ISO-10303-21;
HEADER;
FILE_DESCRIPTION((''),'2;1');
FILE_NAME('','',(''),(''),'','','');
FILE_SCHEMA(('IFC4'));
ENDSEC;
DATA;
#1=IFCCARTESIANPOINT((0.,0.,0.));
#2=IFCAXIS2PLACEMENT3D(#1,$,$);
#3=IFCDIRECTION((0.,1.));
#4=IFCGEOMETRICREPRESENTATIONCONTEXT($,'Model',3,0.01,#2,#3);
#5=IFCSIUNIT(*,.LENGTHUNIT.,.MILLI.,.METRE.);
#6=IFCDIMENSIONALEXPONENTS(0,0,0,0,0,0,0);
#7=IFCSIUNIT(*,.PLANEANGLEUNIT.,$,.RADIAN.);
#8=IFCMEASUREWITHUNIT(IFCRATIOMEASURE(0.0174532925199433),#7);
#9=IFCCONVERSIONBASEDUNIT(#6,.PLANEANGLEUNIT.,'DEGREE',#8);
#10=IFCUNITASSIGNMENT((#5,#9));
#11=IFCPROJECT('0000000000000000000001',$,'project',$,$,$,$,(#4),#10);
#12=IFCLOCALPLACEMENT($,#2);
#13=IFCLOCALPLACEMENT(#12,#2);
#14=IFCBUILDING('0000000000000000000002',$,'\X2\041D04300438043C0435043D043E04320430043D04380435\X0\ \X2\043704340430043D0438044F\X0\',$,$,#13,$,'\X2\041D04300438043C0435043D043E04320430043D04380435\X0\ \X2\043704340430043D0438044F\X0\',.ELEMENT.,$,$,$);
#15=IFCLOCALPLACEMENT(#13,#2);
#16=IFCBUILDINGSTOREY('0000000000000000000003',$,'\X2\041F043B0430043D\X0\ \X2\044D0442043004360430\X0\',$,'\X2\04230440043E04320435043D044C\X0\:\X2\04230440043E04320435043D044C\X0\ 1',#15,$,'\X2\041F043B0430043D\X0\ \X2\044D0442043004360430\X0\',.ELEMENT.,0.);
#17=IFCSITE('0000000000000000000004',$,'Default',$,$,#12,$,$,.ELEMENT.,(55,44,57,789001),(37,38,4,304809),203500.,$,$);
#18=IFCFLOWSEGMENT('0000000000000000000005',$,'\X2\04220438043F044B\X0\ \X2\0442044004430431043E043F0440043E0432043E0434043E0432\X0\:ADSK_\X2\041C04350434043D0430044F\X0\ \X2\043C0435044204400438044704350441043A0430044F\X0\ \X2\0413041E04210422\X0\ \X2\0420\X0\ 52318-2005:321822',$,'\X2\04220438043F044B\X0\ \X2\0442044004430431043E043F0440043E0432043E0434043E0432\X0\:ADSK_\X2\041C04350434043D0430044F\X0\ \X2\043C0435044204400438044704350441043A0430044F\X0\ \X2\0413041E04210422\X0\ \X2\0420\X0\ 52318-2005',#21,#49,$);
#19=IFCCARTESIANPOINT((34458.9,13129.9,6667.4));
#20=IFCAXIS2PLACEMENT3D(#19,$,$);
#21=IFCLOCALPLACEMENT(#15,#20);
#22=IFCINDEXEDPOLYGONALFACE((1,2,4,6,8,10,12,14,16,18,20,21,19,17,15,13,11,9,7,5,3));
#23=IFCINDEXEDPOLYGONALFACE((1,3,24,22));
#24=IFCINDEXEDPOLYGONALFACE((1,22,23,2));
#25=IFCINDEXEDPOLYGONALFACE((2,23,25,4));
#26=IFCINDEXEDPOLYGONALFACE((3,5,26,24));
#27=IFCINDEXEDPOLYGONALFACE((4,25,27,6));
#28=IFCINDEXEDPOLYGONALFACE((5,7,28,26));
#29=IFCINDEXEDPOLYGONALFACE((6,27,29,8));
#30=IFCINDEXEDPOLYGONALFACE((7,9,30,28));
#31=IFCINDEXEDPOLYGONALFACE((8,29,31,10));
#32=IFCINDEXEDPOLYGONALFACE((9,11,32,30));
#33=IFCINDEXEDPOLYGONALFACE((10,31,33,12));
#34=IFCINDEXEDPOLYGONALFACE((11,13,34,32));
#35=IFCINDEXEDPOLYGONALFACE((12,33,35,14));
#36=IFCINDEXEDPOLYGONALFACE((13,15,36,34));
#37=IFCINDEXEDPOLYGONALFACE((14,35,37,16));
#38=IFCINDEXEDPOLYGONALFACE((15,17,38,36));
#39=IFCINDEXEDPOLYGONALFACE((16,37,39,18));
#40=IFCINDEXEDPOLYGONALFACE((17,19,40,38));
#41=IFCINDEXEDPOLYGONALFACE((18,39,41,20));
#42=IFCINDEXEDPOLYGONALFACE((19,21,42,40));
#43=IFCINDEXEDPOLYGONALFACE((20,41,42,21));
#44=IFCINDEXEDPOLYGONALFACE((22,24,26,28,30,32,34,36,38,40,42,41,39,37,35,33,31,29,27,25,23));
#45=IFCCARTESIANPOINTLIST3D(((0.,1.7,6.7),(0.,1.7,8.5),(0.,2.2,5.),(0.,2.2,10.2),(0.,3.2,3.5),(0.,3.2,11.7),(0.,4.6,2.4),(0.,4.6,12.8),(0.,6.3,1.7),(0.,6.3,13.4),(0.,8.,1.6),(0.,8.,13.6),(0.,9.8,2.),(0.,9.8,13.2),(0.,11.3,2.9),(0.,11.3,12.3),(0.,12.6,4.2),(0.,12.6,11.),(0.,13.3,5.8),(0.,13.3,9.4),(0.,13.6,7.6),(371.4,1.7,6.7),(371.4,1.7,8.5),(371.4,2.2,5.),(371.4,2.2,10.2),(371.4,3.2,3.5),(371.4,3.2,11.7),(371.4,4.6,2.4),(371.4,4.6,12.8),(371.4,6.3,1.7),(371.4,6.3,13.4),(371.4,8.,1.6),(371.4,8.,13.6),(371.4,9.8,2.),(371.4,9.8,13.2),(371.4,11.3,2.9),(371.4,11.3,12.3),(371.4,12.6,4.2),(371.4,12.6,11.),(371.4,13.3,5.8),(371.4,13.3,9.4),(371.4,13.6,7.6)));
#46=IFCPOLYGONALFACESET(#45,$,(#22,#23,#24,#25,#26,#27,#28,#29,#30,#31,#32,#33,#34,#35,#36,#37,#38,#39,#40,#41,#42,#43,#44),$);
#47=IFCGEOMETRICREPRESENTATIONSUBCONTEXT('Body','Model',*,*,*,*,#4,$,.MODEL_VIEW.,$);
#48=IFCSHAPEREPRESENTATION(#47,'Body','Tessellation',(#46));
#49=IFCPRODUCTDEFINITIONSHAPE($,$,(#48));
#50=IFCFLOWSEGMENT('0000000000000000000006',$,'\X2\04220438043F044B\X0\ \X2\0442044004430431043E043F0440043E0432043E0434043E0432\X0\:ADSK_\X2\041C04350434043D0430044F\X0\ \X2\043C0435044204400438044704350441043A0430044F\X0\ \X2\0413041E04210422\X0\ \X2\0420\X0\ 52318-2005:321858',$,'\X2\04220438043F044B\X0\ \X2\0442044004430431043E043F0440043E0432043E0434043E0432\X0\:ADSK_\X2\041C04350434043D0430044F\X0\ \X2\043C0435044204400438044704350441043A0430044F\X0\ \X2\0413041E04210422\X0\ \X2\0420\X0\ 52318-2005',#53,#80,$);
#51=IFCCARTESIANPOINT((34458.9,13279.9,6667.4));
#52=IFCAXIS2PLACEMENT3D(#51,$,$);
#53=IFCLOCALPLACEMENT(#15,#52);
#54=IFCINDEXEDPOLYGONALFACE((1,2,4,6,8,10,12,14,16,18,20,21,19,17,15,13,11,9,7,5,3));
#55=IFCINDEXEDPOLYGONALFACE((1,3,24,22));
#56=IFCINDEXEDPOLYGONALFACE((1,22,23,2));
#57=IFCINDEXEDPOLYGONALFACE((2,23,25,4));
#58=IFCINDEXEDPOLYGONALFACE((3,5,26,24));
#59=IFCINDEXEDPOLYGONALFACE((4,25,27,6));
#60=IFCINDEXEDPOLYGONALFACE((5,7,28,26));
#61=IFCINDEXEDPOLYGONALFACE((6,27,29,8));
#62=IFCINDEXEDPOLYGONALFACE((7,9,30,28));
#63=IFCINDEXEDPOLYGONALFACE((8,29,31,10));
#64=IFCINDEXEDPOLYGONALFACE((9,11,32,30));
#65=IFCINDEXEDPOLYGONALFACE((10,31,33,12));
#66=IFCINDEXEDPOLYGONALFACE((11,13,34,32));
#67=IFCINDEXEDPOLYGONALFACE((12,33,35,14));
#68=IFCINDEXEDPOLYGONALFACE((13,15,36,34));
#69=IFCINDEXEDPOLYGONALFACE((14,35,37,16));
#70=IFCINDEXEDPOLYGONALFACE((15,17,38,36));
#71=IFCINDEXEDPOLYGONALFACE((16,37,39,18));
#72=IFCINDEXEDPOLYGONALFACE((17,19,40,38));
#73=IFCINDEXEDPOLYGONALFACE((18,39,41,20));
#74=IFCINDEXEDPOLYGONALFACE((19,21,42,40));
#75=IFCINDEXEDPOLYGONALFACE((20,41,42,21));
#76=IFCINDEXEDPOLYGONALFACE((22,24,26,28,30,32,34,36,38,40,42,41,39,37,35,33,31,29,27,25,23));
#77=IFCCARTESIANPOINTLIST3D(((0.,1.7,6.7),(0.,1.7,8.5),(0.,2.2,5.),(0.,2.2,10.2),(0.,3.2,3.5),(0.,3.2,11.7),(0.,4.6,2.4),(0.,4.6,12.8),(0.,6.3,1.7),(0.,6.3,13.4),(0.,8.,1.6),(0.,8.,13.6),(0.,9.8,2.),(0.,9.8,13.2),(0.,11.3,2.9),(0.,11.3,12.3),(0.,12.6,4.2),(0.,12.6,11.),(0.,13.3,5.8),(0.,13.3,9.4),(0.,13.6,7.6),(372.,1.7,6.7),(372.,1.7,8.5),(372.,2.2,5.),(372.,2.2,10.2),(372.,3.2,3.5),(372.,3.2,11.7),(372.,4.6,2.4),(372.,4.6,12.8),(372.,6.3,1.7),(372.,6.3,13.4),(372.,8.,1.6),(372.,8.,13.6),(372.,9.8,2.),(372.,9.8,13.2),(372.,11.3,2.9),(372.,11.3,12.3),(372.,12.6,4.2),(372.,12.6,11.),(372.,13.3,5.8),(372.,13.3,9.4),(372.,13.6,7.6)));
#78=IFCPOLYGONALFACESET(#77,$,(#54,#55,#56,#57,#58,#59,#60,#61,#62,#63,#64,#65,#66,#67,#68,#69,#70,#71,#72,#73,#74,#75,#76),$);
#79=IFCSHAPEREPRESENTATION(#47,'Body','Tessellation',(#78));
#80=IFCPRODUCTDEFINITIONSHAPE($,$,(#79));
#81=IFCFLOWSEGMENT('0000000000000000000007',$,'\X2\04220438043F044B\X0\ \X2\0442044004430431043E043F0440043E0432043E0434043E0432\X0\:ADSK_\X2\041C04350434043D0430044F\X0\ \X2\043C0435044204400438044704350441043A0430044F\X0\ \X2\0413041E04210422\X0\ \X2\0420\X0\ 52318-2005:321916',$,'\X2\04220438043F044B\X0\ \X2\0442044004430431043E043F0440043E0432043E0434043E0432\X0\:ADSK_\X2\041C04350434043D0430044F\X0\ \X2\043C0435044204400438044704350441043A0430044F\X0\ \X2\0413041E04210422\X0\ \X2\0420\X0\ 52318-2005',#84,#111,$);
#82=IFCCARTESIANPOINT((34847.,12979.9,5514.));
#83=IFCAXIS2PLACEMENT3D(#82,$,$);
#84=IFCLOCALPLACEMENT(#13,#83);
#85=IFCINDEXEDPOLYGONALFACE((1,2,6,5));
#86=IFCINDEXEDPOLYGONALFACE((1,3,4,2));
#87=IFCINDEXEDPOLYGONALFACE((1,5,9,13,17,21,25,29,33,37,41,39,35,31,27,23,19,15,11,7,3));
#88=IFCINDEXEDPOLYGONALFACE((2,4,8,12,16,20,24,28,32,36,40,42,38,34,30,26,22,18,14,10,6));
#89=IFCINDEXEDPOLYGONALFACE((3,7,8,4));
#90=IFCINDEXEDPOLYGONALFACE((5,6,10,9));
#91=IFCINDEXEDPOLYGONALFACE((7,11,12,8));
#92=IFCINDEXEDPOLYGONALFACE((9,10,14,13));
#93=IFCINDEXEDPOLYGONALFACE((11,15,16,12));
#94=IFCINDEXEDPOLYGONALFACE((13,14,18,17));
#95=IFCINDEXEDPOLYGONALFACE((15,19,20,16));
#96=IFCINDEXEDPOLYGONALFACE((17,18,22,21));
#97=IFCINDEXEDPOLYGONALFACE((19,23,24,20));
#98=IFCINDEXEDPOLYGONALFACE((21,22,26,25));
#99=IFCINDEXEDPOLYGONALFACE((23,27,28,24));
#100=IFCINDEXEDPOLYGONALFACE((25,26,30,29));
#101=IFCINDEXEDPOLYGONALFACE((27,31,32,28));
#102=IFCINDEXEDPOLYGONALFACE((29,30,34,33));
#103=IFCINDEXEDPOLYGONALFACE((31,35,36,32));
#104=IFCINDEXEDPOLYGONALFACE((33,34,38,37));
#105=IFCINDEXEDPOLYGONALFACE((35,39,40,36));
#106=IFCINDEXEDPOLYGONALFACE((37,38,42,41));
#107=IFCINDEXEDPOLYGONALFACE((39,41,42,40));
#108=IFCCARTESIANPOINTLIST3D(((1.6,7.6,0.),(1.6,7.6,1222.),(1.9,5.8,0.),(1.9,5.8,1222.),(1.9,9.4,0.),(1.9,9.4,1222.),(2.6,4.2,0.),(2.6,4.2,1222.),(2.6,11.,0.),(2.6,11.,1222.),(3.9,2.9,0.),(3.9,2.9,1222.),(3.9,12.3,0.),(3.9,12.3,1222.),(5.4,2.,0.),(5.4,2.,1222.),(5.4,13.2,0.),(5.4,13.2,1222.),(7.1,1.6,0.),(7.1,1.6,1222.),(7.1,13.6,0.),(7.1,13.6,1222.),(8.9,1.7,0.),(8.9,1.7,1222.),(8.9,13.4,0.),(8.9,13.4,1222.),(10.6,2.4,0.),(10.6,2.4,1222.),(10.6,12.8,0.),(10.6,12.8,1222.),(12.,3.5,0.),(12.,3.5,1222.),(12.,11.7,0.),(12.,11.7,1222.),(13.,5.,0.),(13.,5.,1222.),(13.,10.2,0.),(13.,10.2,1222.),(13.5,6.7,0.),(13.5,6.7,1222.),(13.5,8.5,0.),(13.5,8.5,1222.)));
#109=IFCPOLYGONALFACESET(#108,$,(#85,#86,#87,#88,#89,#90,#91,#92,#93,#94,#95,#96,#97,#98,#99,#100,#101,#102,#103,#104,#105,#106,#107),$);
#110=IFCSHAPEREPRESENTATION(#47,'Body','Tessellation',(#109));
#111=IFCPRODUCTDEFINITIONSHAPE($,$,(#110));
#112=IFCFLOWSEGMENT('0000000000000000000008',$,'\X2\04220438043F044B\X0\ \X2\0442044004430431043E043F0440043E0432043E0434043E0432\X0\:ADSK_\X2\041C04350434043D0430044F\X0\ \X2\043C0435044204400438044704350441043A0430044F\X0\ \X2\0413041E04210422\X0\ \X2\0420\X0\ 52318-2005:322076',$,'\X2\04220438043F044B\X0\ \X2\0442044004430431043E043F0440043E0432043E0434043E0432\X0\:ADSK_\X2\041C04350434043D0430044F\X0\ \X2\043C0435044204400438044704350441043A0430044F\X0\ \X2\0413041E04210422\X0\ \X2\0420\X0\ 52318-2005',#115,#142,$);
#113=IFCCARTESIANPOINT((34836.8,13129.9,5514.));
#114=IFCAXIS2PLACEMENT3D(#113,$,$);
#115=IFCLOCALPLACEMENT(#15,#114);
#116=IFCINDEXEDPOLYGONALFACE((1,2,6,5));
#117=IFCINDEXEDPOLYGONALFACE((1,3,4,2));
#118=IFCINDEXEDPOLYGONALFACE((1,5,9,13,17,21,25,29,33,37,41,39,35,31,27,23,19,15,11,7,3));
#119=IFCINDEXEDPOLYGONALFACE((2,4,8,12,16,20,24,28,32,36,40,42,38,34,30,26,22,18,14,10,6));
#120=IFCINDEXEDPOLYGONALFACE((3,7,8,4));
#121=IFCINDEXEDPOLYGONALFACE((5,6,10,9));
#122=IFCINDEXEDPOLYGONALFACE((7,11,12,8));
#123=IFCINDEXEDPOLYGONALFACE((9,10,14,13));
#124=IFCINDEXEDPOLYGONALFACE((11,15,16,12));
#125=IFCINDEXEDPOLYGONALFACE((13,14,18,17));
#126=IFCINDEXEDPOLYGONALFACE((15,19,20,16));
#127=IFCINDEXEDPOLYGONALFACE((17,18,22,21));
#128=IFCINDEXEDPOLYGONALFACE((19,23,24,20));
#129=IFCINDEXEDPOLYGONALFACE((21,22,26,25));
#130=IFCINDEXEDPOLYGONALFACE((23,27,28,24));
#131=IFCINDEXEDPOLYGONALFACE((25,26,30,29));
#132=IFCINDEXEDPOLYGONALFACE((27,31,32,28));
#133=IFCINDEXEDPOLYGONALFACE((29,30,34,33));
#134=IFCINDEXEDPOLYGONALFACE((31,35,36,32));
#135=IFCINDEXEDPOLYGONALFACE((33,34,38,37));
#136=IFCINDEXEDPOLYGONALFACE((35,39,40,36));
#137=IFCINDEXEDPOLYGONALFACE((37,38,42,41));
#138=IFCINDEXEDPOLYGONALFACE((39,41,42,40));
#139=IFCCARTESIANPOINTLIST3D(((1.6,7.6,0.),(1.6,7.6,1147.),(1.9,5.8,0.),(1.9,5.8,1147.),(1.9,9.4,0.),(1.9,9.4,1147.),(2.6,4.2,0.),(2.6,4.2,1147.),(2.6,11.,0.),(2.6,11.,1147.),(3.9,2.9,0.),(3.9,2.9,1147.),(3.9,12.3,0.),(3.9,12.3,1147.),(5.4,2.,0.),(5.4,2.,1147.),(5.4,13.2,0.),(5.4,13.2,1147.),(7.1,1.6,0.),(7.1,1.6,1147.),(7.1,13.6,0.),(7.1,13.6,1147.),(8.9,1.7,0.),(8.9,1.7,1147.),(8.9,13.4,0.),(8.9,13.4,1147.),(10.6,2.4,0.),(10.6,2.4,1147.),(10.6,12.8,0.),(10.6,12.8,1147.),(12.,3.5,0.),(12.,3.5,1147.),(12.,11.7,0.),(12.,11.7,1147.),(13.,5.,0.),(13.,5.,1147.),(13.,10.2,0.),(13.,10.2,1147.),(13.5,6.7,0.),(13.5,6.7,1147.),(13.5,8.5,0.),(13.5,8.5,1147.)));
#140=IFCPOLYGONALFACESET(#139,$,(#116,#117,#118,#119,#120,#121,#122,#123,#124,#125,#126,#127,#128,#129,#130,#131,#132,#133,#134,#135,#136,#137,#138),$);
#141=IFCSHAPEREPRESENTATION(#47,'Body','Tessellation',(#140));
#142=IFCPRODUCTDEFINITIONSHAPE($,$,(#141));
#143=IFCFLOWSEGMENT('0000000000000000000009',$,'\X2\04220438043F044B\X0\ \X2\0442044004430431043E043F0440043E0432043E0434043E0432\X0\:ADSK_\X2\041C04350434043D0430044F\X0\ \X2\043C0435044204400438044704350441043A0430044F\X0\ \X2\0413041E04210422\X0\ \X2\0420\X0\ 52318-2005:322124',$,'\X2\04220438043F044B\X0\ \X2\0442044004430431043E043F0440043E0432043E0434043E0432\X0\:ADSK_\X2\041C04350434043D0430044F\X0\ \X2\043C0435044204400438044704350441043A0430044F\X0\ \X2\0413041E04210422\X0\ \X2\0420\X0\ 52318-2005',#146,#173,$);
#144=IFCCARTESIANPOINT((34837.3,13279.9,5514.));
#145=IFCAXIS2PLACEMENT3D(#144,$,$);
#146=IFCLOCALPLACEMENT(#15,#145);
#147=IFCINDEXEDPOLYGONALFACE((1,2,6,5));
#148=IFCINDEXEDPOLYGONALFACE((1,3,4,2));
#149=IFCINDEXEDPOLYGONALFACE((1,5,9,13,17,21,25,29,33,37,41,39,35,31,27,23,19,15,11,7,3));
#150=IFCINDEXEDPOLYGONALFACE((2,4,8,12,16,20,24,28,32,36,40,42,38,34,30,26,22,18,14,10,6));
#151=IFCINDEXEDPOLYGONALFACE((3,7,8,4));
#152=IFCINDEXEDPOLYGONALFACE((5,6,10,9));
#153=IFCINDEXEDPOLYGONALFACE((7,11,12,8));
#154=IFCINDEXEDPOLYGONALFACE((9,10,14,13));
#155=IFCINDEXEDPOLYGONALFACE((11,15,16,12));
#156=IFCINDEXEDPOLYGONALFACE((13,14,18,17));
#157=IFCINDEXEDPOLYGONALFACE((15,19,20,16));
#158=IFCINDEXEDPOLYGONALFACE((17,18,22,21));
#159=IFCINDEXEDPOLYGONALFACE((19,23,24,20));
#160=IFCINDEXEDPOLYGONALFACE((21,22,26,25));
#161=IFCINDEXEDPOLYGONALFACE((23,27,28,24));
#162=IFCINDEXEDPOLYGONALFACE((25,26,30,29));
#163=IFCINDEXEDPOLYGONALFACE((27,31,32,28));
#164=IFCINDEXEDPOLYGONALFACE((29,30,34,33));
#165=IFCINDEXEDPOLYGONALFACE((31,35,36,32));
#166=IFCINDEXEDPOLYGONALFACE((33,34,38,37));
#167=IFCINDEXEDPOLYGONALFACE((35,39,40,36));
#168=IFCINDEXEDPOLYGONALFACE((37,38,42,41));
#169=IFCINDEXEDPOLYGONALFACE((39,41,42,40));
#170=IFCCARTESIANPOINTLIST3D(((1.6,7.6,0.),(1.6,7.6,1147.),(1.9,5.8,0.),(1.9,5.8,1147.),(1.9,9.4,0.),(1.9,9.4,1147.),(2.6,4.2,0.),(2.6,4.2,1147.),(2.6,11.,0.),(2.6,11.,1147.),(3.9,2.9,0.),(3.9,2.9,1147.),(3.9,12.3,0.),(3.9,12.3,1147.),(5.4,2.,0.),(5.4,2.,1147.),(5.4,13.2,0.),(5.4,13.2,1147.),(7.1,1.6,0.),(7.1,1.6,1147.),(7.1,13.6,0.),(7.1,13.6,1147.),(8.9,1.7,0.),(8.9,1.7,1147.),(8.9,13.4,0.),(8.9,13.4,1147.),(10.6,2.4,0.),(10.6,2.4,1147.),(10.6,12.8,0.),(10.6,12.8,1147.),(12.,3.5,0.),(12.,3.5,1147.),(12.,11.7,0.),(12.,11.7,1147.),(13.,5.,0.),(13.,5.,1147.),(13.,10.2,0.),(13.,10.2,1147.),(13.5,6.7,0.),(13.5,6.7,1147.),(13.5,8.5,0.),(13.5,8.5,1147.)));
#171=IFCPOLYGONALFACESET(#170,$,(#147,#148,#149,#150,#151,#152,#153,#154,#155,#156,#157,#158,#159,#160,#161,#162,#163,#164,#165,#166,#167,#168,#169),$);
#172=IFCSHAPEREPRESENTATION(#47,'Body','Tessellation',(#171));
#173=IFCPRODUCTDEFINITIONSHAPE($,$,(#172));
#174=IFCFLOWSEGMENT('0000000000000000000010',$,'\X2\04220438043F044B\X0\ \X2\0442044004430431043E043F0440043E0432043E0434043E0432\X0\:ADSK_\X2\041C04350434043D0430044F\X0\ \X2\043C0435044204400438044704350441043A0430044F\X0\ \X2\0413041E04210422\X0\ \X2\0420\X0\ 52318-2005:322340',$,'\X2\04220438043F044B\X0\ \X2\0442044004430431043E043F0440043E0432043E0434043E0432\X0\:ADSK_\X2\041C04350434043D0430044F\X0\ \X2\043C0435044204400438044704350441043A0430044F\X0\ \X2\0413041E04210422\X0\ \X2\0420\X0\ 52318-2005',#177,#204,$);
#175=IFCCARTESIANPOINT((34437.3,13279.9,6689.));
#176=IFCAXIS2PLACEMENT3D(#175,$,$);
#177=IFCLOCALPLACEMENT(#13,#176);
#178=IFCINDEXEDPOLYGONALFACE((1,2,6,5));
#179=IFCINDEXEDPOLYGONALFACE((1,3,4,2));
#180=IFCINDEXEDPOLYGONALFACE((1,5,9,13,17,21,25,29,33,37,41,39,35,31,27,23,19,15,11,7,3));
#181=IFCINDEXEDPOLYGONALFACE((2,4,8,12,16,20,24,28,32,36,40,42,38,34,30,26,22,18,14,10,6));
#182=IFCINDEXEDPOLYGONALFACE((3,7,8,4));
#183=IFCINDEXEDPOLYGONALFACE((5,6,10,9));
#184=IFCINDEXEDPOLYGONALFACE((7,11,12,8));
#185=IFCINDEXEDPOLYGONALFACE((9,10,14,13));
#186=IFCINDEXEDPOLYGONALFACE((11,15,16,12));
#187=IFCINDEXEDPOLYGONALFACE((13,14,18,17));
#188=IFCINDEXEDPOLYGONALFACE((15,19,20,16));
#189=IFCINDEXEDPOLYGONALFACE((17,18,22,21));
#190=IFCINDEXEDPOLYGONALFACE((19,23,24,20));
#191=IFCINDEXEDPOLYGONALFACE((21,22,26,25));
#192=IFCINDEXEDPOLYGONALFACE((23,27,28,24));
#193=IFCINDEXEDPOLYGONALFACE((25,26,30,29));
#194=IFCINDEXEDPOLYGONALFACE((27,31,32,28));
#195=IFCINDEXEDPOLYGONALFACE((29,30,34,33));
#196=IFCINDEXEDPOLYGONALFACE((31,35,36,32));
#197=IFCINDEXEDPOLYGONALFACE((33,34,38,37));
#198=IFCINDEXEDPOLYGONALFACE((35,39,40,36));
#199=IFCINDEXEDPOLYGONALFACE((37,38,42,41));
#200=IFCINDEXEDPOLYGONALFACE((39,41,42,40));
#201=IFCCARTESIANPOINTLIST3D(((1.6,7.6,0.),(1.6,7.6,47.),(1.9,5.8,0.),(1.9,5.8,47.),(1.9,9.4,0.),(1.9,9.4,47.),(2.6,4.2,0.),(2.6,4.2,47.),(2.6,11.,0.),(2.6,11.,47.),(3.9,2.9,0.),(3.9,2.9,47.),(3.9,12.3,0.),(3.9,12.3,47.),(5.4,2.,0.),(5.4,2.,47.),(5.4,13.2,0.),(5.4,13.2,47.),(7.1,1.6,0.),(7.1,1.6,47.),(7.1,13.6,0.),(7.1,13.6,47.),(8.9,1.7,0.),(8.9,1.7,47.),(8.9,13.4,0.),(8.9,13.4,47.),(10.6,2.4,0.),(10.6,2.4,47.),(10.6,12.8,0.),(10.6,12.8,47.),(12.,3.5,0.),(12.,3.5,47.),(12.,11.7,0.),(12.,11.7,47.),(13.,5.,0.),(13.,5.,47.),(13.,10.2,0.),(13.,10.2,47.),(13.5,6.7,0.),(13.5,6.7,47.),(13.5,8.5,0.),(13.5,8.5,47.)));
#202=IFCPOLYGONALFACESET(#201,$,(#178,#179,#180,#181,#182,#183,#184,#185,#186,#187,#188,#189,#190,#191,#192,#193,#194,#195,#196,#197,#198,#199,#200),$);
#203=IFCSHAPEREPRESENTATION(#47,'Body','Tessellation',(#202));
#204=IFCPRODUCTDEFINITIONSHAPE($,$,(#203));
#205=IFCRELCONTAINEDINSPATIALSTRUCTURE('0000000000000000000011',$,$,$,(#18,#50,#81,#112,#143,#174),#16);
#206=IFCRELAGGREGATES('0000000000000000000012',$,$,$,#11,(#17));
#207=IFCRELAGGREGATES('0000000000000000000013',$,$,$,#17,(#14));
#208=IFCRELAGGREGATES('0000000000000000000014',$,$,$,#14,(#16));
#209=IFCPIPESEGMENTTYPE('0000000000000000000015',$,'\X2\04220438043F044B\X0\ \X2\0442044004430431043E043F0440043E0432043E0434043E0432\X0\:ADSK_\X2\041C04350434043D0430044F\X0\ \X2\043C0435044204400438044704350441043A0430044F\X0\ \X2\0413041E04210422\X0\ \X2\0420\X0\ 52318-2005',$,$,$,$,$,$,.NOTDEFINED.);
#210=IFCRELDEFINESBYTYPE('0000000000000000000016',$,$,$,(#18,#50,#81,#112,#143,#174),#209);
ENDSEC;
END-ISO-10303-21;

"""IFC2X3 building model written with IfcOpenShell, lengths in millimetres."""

from ifc_helpers import new_model, entity, si_unit, converted_unit, direction, frame, frame_2d, origin, origin_2d_with_axis, place, context, subcontext, project, spatial, circle, extrude, type_object, element, save


model = new_model("IFC2X3")

# Units and contexts
model_context = context("Model", 3, precision=0.01, world=origin(), true_north=direction((0.0, 1.0)))
body_context = subcontext(model_context, "Body", "Model", "MODEL_VIEW")
ifc_project = project(units=[si_unit("LENGTHUNIT", "METRE", prefix="MILLI"), converted_unit("PLANEANGLEUNIT", "DEGREE", entity("IfcRatioMeasure", 0.0174532925199433), si_unit("PLANEANGLEUNIT", "RADIAN"), dimensions=[0, 0, 0, 0, 0, 0, 0])], contexts=[model_context])

# Site, building, storey
site_placement = place(None, frame((0.0, 0.0, 0.0)))
site = spatial("IfcSite", under=ifc_project, at=site_placement, Name="Default", CompositionType="ELEMENT", RefLatitude=(55, 44, 57, 789001), RefLongitude=(37, 38, 4, 304809), RefElevation=203500.0)
building_placement = place(site_placement, origin())
building = spatial("IfcBuilding", under=site, at=building_placement, Name="Наименование здания", LongName="Наименование здания", CompositionType="ELEMENT")
storey_placement = place(building_placement, origin())
storey = spatial("IfcBuildingStorey", under=building, at=storey_placement, Name="План этажа", ObjectType="Уровень:Уровень 1", LongName="План этажа", CompositionType="ELEMENT", Elevation=0.0)

# Flow segments
pipe_segment_type = type_object("IfcPipeSegmentType", Name="Типы трубопроводов:ADSK_Медная метрическая ГОСТ Р 52318-2005", PredefinedType="NOTDEFINED")
flow_segment_1_placement = place(storey_placement, frame((34458.9, 13129.9, 6667.4)))
element("IfcFlowSegment", 1, at=flow_segment_1_placement, inside=storey, type_object=pipe_segment_type, Name="Типы трубопроводов:ADSK_Медная метрическая ГОСТ Р 52318-2005:321822", ObjectType="Типы трубопроводов:ADSK_Медная метрическая ГОСТ Р 52318-2005", context=body_context, shape_type="SweptSolid", body=[
    extrude(circle(Radius=6.0, at=frame_2d((0.0, 0.0), x_axis=(1.0, 0.0))), frame((0.0, 7.6, 7.6), z_axis=(1.0, 0.0, 0.0), x_axis=(0.0, 1.0, 0.0)), (0.0, 0.0, 1.0), 371.4),
])
flow_segment_2_placement = place(storey_placement, frame((34458.9, 13279.9, 6667.4)))
element("IfcFlowSegment", 2, at=flow_segment_2_placement, inside=storey, type_object=pipe_segment_type, Name="Типы трубопроводов:ADSK_Медная метрическая ГОСТ Р 52318-2005:321858", ObjectType="Типы трубопроводов:ADSK_Медная метрическая ГОСТ Р 52318-2005", context=body_context, shape_type="SweptSolid", body=[
    extrude(circle(Radius=6.0, at=frame_2d((0.0, 0.0), x_axis=(1.0, 0.0))), frame((0.0, 7.6, 7.6), z_axis=(1.0, 0.0, 0.0), x_axis=(0.0, 1.0, 0.0)), (0.0, 0.0, 1.0), 372.0),
])
flow_segment_3_placement = place(building_placement, frame((34847.0, 12979.9, 5514.0)))
element("IfcFlowSegment", 3, at=flow_segment_3_placement, inside=storey, type_object=pipe_segment_type, Name="Типы трубопроводов:ADSK_Медная метрическая ГОСТ Р 52318-2005:321916", ObjectType="Типы трубопроводов:ADSK_Медная метрическая ГОСТ Р 52318-2005", context=body_context, shape_type="SweptSolid", body=[
    extrude(circle(Radius=6.0, at=frame_2d((0.0, 0.0), x_axis=(1.0, 0.0))), frame((7.6, 7.6, 0.0), z_axis=(0.0, 0.0, 1.0), x_axis=(-1.0, 0.0, 0.0)), (0.0, 0.0, 1.0), 1222.0),
])
flow_segment_4_placement = place(storey_placement, frame((34836.8, 13129.9, 5514.0)))
element("IfcFlowSegment", 4, at=flow_segment_4_placement, inside=storey, type_object=pipe_segment_type, Name="Типы трубопроводов:ADSK_Медная метрическая ГОСТ Р 52318-2005:322076", ObjectType="Типы трубопроводов:ADSK_Медная метрическая ГОСТ Р 52318-2005", context=body_context, shape_type="SweptSolid", body=[
    extrude(circle(Radius=6.0, at=origin_2d_with_axis()), frame((7.6, 7.6, 0.0), z_axis=(0.0, 0.0, 1.0), x_axis=(-1.0, 0.0, 0.0)), (0.0, 0.0, 1.0), 1147.0),
])
flow_segment_5_placement = place(storey_placement, frame((34837.3, 13279.9, 5514.0)))
element("IfcFlowSegment", 5, at=flow_segment_5_placement, inside=storey, type_object=pipe_segment_type, Name="Типы трубопроводов:ADSK_Медная метрическая ГОСТ Р 52318-2005:322124", ObjectType="Типы трубопроводов:ADSK_Медная метрическая ГОСТ Р 52318-2005", context=body_context, shape_type="SweptSolid", body=[
    extrude(circle(Radius=6.0, at=frame_2d((0.0, 0.0), x_axis=(1.0, 0.0))), frame((7.6, 7.6, 0.0), z_axis=(0.0, 0.0, 1.0), x_axis=(-1.0, 0.0, 0.0)), (0.0, 0.0, 1.0), 1147.0),
])
flow_segment_6_placement = place(building_placement, frame((34437.3, 13279.9, 6689.0)))
element("IfcFlowSegment", 6, at=flow_segment_6_placement, inside=storey, type_object=pipe_segment_type, Name="Типы трубопроводов:ADSK_Медная метрическая ГОСТ Р 52318-2005:322340", ObjectType="Типы трубопроводов:ADSK_Медная метрическая ГОСТ Р 52318-2005", context=body_context, shape_type="SweptSolid", body=[
    extrude(circle(Radius=6.0, at=origin_2d_with_axis()), frame((7.6, 7.6, 0.0), z_axis=(0.0, 0.0, 1.0), x_axis=(-1.0, 0.0, 0.0)), (0.0, 0.0, 1.0), 47.0),
])

save(model, "model.ifc")
